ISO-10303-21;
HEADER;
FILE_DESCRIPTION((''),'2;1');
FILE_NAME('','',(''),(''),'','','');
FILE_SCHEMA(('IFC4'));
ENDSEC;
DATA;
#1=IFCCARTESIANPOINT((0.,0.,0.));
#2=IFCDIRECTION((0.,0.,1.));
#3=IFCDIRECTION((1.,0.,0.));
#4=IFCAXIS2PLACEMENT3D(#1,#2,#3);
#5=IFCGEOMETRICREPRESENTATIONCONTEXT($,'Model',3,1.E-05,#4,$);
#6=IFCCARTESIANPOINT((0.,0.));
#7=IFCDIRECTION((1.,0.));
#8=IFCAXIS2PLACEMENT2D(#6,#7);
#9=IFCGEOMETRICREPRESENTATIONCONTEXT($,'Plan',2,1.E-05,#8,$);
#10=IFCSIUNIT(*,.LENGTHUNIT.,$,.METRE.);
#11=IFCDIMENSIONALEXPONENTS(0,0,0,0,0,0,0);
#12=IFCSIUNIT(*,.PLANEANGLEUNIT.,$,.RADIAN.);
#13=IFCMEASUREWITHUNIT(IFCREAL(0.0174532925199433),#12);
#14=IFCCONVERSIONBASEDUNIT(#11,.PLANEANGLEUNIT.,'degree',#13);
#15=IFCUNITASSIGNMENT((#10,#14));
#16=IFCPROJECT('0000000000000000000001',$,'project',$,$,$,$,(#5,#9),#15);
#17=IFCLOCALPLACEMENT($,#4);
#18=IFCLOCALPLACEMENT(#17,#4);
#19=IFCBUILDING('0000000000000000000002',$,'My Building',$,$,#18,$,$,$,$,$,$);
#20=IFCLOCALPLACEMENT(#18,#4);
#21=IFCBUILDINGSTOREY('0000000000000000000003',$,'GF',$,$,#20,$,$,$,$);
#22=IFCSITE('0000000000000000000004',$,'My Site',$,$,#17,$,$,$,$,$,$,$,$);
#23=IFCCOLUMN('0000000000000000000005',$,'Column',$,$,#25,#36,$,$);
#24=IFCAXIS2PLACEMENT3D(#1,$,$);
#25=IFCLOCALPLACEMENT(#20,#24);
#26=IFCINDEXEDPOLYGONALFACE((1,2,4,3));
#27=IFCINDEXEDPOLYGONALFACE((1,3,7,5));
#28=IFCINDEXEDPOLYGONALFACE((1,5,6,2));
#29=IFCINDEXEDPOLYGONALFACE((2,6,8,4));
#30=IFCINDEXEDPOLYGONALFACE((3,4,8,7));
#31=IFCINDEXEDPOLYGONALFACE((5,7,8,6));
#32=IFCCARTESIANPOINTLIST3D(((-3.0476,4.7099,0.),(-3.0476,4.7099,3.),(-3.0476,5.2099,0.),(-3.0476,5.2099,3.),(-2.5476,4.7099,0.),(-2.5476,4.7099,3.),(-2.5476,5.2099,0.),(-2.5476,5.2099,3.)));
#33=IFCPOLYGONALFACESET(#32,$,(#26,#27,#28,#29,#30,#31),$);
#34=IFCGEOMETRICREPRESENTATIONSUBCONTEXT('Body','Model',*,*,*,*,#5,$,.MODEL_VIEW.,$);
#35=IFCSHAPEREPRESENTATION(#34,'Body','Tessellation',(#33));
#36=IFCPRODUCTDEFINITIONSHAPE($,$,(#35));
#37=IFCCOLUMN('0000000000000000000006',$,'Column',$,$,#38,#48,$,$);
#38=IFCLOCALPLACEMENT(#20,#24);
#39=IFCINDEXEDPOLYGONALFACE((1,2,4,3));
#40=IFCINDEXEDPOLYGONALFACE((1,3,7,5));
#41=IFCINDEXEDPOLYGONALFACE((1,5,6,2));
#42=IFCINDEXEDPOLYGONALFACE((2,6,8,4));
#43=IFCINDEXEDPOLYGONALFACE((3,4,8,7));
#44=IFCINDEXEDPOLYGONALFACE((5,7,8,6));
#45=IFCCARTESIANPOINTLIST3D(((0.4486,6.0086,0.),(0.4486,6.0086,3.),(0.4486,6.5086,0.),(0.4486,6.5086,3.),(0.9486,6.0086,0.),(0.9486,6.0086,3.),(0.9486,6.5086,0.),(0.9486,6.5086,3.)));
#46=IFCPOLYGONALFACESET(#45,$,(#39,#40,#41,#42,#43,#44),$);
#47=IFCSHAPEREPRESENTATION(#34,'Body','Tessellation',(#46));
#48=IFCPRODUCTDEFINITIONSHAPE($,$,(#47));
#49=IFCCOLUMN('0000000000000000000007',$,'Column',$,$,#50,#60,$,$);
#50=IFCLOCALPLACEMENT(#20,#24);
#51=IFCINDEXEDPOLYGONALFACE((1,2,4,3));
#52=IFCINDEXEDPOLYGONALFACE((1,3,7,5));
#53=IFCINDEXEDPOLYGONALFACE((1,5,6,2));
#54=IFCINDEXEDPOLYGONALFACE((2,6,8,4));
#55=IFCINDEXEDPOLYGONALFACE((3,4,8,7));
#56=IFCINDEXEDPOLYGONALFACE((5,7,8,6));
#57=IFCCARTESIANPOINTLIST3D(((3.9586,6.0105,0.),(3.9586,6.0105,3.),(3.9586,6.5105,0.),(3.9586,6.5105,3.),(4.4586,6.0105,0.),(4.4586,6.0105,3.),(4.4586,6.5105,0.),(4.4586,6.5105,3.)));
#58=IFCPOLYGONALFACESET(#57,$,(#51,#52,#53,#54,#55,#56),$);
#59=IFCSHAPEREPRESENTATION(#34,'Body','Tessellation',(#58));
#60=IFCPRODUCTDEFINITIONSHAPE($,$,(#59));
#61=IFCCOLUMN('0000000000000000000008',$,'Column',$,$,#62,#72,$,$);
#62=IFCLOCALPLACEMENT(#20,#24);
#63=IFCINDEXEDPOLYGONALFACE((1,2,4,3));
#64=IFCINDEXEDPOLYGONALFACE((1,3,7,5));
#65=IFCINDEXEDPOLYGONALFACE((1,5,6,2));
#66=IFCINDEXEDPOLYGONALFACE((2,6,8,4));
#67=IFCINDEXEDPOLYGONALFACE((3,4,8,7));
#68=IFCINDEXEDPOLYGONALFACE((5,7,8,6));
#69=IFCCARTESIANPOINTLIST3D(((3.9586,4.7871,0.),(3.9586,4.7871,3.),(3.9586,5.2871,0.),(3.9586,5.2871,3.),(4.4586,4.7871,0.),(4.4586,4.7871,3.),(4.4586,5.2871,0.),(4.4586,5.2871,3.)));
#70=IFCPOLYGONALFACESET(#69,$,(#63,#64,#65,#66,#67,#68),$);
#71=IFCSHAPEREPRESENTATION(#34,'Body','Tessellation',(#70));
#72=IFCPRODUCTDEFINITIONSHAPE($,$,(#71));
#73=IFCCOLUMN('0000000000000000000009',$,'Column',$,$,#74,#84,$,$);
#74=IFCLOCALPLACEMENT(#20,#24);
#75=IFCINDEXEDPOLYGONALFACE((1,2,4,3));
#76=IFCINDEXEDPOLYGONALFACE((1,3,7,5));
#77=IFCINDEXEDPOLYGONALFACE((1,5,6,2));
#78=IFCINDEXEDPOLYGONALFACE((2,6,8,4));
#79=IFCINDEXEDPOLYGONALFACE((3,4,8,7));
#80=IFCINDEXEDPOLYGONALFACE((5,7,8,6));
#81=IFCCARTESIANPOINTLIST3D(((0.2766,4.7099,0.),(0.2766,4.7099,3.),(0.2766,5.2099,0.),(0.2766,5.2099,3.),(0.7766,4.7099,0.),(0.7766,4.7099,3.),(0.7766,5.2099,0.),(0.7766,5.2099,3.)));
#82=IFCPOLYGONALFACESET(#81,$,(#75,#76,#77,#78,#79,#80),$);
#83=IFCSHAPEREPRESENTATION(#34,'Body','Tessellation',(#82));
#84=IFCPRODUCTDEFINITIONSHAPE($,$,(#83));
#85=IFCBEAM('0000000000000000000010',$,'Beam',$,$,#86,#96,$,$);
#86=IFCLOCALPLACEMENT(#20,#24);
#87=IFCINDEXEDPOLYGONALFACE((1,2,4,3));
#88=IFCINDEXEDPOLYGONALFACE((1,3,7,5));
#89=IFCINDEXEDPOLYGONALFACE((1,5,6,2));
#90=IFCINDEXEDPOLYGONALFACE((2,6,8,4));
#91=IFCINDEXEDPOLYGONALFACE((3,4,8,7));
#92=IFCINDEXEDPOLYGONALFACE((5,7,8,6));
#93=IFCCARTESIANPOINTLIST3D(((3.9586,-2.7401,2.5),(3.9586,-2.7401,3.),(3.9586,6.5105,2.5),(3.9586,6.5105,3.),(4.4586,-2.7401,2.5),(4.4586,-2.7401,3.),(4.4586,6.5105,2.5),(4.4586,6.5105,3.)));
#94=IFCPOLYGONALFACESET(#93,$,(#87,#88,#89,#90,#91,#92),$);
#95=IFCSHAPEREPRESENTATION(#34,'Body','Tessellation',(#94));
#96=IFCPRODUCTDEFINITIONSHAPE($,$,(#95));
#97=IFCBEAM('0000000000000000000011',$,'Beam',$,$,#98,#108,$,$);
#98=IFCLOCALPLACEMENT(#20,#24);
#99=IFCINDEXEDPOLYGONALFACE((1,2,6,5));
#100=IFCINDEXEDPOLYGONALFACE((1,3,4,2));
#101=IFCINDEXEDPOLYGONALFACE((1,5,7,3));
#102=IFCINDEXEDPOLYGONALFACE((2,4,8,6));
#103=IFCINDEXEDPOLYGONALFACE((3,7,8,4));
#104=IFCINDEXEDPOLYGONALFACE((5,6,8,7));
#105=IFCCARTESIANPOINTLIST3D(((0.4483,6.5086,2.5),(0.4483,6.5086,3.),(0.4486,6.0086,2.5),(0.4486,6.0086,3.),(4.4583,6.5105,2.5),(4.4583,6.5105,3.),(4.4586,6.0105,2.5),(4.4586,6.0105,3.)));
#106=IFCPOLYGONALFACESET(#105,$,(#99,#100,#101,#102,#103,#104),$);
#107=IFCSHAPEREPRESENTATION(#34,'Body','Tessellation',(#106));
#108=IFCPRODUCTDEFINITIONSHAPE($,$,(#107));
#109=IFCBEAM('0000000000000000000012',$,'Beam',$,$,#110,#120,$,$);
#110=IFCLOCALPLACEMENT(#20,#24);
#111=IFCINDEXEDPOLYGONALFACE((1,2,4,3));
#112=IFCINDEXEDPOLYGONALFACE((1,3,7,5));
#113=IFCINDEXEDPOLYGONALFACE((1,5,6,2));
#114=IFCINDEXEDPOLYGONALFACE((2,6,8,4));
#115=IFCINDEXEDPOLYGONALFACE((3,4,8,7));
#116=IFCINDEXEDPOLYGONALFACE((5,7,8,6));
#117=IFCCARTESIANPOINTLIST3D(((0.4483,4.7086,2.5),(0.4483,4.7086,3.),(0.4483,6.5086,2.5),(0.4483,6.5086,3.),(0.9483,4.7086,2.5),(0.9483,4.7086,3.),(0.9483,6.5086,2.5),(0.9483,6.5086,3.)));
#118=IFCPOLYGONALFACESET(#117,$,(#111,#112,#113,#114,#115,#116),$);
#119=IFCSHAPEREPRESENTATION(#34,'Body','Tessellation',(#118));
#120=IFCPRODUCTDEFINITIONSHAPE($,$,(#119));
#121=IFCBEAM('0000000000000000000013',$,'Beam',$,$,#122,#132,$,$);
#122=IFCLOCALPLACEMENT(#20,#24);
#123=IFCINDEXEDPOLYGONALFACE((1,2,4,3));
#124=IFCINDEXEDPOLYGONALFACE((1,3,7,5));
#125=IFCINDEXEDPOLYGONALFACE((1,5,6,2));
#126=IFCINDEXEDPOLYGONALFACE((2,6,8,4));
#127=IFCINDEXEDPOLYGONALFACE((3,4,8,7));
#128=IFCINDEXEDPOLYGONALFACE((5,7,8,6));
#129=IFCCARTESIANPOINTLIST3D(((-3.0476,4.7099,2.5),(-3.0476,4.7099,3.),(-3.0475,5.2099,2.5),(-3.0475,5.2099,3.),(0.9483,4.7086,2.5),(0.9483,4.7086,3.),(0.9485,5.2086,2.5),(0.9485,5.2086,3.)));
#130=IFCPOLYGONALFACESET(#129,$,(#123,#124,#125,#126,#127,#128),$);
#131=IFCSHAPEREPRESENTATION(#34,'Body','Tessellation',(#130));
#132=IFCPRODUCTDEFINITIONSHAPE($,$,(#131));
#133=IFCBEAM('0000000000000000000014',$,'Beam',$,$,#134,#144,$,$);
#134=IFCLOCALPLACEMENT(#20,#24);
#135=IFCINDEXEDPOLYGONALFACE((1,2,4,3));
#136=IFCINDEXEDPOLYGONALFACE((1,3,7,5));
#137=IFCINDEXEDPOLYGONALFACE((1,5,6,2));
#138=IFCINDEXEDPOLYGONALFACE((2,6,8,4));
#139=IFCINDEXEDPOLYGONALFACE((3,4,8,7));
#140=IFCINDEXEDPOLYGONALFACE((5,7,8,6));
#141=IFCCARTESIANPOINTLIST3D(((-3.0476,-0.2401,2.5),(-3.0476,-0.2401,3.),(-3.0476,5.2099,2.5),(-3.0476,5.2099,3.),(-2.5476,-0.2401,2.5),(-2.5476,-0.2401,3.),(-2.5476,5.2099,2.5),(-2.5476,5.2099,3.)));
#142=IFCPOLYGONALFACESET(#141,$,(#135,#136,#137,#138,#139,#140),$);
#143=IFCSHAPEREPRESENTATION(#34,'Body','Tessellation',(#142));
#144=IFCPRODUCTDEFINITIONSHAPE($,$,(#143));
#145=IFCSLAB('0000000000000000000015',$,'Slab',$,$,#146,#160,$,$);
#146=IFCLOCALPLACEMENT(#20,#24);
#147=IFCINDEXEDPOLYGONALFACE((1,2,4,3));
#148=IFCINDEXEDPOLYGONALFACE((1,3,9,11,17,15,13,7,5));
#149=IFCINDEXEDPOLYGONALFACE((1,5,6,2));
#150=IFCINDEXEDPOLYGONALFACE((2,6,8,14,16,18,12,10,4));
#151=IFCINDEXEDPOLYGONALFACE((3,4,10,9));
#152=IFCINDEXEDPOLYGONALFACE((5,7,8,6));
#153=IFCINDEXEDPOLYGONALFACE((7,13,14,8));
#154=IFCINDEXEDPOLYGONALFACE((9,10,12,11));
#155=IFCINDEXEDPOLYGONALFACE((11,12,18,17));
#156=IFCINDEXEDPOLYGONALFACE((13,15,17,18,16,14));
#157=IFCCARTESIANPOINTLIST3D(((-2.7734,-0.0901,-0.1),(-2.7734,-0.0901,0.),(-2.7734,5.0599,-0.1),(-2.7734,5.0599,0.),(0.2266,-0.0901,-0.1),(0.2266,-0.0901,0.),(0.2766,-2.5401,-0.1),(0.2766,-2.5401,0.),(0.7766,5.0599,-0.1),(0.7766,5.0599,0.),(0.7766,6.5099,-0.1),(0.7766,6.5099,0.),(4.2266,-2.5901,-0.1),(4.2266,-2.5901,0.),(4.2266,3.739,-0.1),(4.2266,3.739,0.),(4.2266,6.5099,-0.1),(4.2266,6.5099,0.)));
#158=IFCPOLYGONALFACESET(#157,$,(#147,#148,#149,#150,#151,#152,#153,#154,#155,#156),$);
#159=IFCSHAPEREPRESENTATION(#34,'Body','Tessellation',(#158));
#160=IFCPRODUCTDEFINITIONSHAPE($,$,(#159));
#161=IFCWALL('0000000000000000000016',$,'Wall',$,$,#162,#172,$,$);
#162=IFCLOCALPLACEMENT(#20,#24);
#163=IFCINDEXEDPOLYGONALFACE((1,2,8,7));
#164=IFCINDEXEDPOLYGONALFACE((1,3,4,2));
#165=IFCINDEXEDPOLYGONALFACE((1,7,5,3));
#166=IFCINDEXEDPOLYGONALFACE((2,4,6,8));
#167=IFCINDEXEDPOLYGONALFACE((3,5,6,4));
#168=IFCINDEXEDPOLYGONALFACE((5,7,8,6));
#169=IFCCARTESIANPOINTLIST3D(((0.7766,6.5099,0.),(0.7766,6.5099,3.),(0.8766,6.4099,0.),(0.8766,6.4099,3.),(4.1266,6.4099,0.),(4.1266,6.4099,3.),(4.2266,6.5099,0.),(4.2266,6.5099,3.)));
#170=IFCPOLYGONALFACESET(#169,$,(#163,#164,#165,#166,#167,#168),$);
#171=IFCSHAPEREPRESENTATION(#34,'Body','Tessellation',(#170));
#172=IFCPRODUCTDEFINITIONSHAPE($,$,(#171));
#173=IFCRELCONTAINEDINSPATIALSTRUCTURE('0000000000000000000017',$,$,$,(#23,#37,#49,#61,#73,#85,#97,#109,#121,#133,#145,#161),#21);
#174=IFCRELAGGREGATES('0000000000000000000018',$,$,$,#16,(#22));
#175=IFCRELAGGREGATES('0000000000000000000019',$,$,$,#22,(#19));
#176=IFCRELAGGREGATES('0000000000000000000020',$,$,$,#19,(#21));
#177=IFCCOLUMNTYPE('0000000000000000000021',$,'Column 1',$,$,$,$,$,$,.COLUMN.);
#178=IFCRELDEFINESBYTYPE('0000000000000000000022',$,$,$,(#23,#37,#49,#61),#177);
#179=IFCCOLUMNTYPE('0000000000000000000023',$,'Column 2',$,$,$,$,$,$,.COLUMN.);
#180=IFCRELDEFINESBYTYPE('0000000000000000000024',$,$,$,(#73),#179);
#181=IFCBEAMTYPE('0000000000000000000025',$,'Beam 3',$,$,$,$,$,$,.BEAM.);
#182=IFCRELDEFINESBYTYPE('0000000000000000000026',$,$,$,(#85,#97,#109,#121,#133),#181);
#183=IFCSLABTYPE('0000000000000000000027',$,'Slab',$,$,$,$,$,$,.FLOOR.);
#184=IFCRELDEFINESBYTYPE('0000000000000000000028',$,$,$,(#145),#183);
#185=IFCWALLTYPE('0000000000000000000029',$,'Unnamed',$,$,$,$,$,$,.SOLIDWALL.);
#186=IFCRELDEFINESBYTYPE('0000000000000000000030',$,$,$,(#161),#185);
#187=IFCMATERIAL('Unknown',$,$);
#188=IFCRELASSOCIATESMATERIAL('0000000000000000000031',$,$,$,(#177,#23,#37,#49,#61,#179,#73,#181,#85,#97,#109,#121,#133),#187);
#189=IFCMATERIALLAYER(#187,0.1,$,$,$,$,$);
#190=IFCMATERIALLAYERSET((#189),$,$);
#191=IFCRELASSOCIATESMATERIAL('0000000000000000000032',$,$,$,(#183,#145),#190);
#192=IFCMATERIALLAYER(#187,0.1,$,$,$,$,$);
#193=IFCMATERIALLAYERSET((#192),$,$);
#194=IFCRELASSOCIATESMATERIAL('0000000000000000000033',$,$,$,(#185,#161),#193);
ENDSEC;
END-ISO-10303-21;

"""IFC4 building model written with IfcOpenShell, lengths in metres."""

from ifc_helpers import new_model, entity, si_unit, converted_unit, frame, origin_with_axes, origin_2d_with_axis, place, context, subcontext, project, spatial, line, indexed_curve, outline, extrude, material, layer, layer_set, layer_usage, material_profile, profile_set, profile_usage, type_object, element, save


model = new_model("IFC4")

# Units and contexts
model_context = context("Model", 3, precision=1e-05, world=origin_with_axes())
plan_context = context("Plan", 2, precision=1e-05, world=origin_2d_with_axis())
body_context_1 = subcontext(model_context, "Body", "Model", "MODEL_VIEW")
ifc_project = project(units=[si_unit("LENGTHUNIT", "METRE"), converted_unit("PLANEANGLEUNIT", "degree", entity("IfcReal", 0.0174532925199433), si_unit("PLANEANGLEUNIT", "RADIAN"), dimensions=[0, 0, 0, 0, 0, 0, 0])], contexts=[model_context, plan_context])

# Site, building, storey
site_placement = place(None, origin_with_axes())
site = spatial("IfcSite", under=ifc_project, at=site_placement, Name="My Site")
building_placement = place(site_placement, origin_with_axes())
building = spatial("IfcBuilding", under=site, at=building_placement, Name="My Building")
storey_placement = place(building_placement, origin_with_axes())
storey = spatial("IfcBuildingStorey", under=building, at=storey_placement, Name="GF")

# Columns
ifc_material = material(Name="Unknown")
ifc_material_profile_1 = material_profile(ifc_material, outline(indexed_curve([(-0.25, -0.25), (0.25, -0.25), (0.25, 0.25), (-0.25, 0.25), (-0.25, -0.25)])))
ifc_profile_set_1 = profile_set([ifc_material_profile_1])
ifc_profile_usage_1 = profile_usage(ifc_profile_set_1, cardinal=5)
column_type_1 = type_object("IfcColumnType", Name="Column 1", PredefinedType="COLUMN", material=ifc_profile_set_1)
column_1_placement = place(storey_placement, frame((-2.7976, 4.9599, 0.0), z_axis=(0.0, 0.0, 1.0), x_axis=(1.0, 0.0, 0.0)))
element("IfcColumn", 1, at=column_1_placement, inside=storey, type_object=column_type_1, material=ifc_profile_usage_1, Name="Column", context=body_context_1, shape_type="SweptSolid", body=[
    extrude(outline(indexed_curve([(-0.25, -0.25), (0.25, -0.25), (0.25, 0.25), (-0.25, 0.25), (-0.25, -0.25)])), origin_with_axes(), (0.0, 0.0, 1.0), 3.0),
])
ifc_profile_usage_2 = profile_usage(ifc_profile_set_1, cardinal=5)
column_2_placement = place(storey_placement, frame((0.6986, 6.2586, 0.0), z_axis=(0.0, 0.0, 1.0), x_axis=(1.0, 0.0, 0.0)))
element("IfcColumn", 2, at=column_2_placement, inside=storey, type_object=column_type_1, material=ifc_profile_usage_2, Name="Column", context=body_context_1, shape_type="SweptSolid", body=[
    extrude(outline(indexed_curve([(-0.25, -0.25), (0.25, -0.25), (0.25, 0.25), (-0.25, 0.25), (-0.25, -0.25)])), origin_with_axes(), (0.0, 0.0, 1.0), 3.0),
])
ifc_profile_usage_3 = profile_usage(ifc_profile_set_1, cardinal=5)
column_3_placement = place(storey_placement, frame((4.2086, 6.2605, 0.0), z_axis=(0.0, 0.0, 1.0), x_axis=(1.0, 0.0, 0.0)))
element("IfcColumn", 3, at=column_3_placement, inside=storey, type_object=column_type_1, material=ifc_profile_usage_3, Name="Column", context=body_context_1, shape_type="SweptSolid", body=[
    extrude(outline(indexed_curve([(-0.25, -0.25), (0.25, -0.25), (0.25, 0.25), (-0.25, 0.25), (-0.25, -0.25)])), origin_with_axes(), (0.0, 0.0, 1.0), 3.0),
])
ifc_profile_usage_4 = profile_usage(ifc_profile_set_1, cardinal=5)
column_4_placement = place(storey_placement, frame((4.2086, 5.0371, 0.0), z_axis=(0.0, 0.0, 1.0), x_axis=(1.0, 0.0, 0.0)))
element("IfcColumn", 4, at=column_4_placement, inside=storey, type_object=column_type_1, material=ifc_profile_usage_4, Name="Column", context=body_context_1, shape_type="SweptSolid", body=[
    extrude(outline(indexed_curve([(-0.25, -0.25), (0.25, -0.25), (0.25, 0.25), (-0.25, 0.25), (-0.25, -0.25)])), origin_with_axes(), (0.0, 0.0, 1.0), 3.0),
])
ifc_material_profile_2 = material_profile(ifc_material, outline(indexed_curve([(-0.25, -0.25), (0.25, -0.25), (0.25, 0.25), (-0.25, 0.25), (-0.25, -0.25)])))
ifc_profile_set_2 = profile_set([ifc_material_profile_2])
ifc_profile_usage_5 = profile_usage(ifc_profile_set_2)
column_type_2 = type_object("IfcColumnType", Name="Column 2", PredefinedType="COLUMN", material=ifc_profile_set_2)
column_5_placement = place(storey_placement, frame((0.5266, 4.9599, 0.0), z_axis=(0.0, 0.0, 1.0), x_axis=(1.0, 0.0, 0.0)))
element("IfcColumn", 5, at=column_5_placement, inside=storey, type_object=column_type_2, material=ifc_profile_usage_5, Name="Column", context=body_context_1, shape_type="SweptSolid", body=[
    extrude(outline(indexed_curve([(-0.25, -0.25), (0.25, -0.25), (0.25, 0.25), (-0.25, 0.25), (-0.25, -0.25)])), origin_with_axes(), (0.0, 0.0, 1.0), 3.0),
])

# Beams
ifc_material_profile_3 = material_profile(ifc_material, outline(indexed_curve([(-0.25, -0.25), (0.25, -0.25), (0.25, 0.25), (-0.25, 0.25), (-0.25, -0.25)])))
ifc_profile_set_3 = profile_set([ifc_material_profile_3])
ifc_profile_usage_6 = profile_usage(ifc_profile_set_3, cardinal=7)
beam_type = type_object("IfcBeamType", Name="Beam 3", PredefinedType="BEAM", material=ifc_profile_set_3)
beam_1_placement = place(storey_placement, frame((4.4586, 6.5105, 3.0), z_axis=(0.0, -1.0, 0.0), x_axis=(1.0, 0.0, 0.0)))
element("IfcBeam", 6, at=beam_1_placement, inside=storey, type_object=beam_type, material=ifc_profile_usage_6, Name="Beam", context=body_context_1, shape_type="SweptSolid", body=[
    extrude(outline(indexed_curve([(-0.25, -0.25), (0.25, -0.25), (0.25, 0.25), (-0.25, 0.25), (-0.25, -0.25)])), frame((-0.25, -0.25, 0.0), z_axis=(0.0, 0.0, 1.0), x_axis=(1.0, 0.0, 0.0)), (0.0, 0.0, 1.0), 9.2506),
])
ifc_profile_usage_7 = profile_usage(ifc_profile_set_3, cardinal=7)
beam_2_placement = place(storey_placement, frame((4.4586, 6.0105, 3.0), z_axis=(-1.0, -0.000475, 0.0), x_axis=(0.000475, -1.0, 0.0)))
element("IfcBeam", 7, at=beam_2_placement, inside=storey, type_object=beam_type, material=ifc_profile_usage_7, Name="Beam", context=body_context_1, shape_type="SweptSolid", body=[
    extrude(outline(indexed_curve([(-0.25, -0.25), (0.25, -0.25), (0.25, 0.25), (-0.25, 0.25), (-0.25, -0.25)])), frame((-0.25, -0.25, 0.0), z_axis=(0.0, 0.0, 1.0), x_axis=(1.0, 0.0, 0.0)), (0.0, 0.0, 1.0), 4.01),
])
ifc_profile_usage_8 = profile_usage(ifc_profile_set_3, cardinal=9)
beam_3_placement = place(storey_placement, frame((0.4483, 6.5086, 3.0), z_axis=(0.0, -1.0, -0.000001), x_axis=(1.0, 0.0, 0.0)))
element("IfcBeam", 8, at=beam_3_placement, inside=storey, type_object=beam_type, material=ifc_profile_usage_8, Name="Beam", context=body_context_1, shape_type="SweptSolid", body=[
    extrude(outline(indexed_curve([(-0.25, -0.25), (0.25, -0.25), (0.25, 0.25), (-0.25, 0.25), (-0.25, -0.25)])), frame((0.25, -0.25, 0.0), z_axis=(0.0, 0.0, 1.0), x_axis=(1.0, 0.0, 0.0)), (0.0, 0.0, 1.0), 1.8),
])
ifc_profile_usage_9 = profile_usage(ifc_profile_set_3, cardinal=7)
beam_4_placement = place(storey_placement, frame((0.9483, 4.7086, 3.0), z_axis=(-1.0, 0.000335, 0.0), x_axis=(-0.000335, -1.0, 0.0)))
element("IfcBeam", 9, at=beam_4_placement, inside=storey, type_object=beam_type, material=ifc_profile_usage_9, Name="Beam", context=body_context_1, shape_type="SweptSolid", body=[
    extrude(outline(indexed_curve([(-0.25, -0.25), (0.25, -0.25), (0.25, 0.25), (-0.25, 0.25), (-0.25, -0.25)])), frame((-0.25, -0.25, 0.0), z_axis=(0.0, 0.0, 1.0), x_axis=(1.0, 0.0, 0.0)), (0.0, 0.0, 1.0), 3.996),
])
ifc_profile_usage_10 = profile_usage(ifc_profile_set_3, cardinal=7)
beam_5_placement = place(storey_placement, frame((-2.5476, 5.2099, 3.0), z_axis=(0.0, -1.0, 0.0), x_axis=(1.0, 0.0, 0.0)))
element("IfcBeam", 10, at=beam_5_placement, inside=storey, type_object=beam_type, material=ifc_profile_usage_10, Name="Beam", context=body_context_1, shape_type="SweptSolid", body=[
    extrude(outline(indexed_curve([(-0.25, -0.25), (0.25, -0.25), (0.25, 0.25), (-0.25, 0.25), (-0.25, -0.25)])), frame((-0.25, -0.25, 0.0), z_axis=(0.0, 0.0, 1.0), x_axis=(1.0, 0.0, 0.0)), (0.0, 0.0, 1.0), 5.45),
])

# Slab
ifc_layer_1 = layer(ifc_material, 0.1)
ifc_layer_set_1 = layer_set([ifc_layer_1])
ifc_layer_usage_1 = layer_usage(ifc_layer_set_1, "AXIS3", "POSITIVE", -0.1)
slab_type = type_object("IfcSlabType", Name="Slab", PredefinedType="FLOOR", material=ifc_layer_set_1)
slab_placement = place(storey_placement, frame((4.2266, 6.5099, 0.0), z_axis=(0.0, 0.0, 1.0), x_axis=(1.0, 0.0, 0.0)))
element("IfcSlab", 11, at=slab_placement, inside=storey, type_object=slab_type, material=ifc_layer_usage_1, Name="Slab", context=body_context_1, shape_type="SweptSolid", body=[
    extrude(outline(indexed_curve([(0.0, 0.0), (-3.45, 0.0), (-3.45, -1.45), (-7.0, -1.45), (-7.0, -6.6), (-4.0, -6.6), (-3.95, -9.05), (0.0, -9.1), (0.0, -2.7709), (0.0, 0.0)])), frame((0.0, 0.0, -0.1), z_axis=(0.0, 0.0, 1.0), x_axis=(1.0, 0.0, 0.0)), (0.0, 0.0, 1.0), 0.1),
])

# Wall
ifc_layer_2 = layer(ifc_material, 0.1)
ifc_layer_set_2 = layer_set([ifc_layer_2])
ifc_layer_usage_2 = layer_usage(ifc_layer_set_2, "AXIS2", "POSITIVE", 0.0)
wall_type = type_object("IfcWallType", Name="Unnamed", PredefinedType="SOLIDWALL", material=ifc_layer_set_2)
wall_1_placement = place(storey_placement, frame((4.2266, 6.5099, 0.0), z_axis=(0.0, 0.0, 1.0), x_axis=(-1.0, 0.0, 0.0)))
element("IfcWall", 12, at=wall_1_placement, inside=storey, type_object=wall_type, material=ifc_layer_usage_2, Name="Wall", context=body_context_1, shape_type="SweptSolid", body=[
    extrude(outline(indexed_curve([(0.0, 0.0), (0.1, 0.1), (3.35, 0.1), (3.45, 0.0)], segments=[line(1, 2, 3, 4, 1)])), origin_with_axes(), (0.0, 0.0, 1.0), 3.0),
])

save(model, "model.ifc")
